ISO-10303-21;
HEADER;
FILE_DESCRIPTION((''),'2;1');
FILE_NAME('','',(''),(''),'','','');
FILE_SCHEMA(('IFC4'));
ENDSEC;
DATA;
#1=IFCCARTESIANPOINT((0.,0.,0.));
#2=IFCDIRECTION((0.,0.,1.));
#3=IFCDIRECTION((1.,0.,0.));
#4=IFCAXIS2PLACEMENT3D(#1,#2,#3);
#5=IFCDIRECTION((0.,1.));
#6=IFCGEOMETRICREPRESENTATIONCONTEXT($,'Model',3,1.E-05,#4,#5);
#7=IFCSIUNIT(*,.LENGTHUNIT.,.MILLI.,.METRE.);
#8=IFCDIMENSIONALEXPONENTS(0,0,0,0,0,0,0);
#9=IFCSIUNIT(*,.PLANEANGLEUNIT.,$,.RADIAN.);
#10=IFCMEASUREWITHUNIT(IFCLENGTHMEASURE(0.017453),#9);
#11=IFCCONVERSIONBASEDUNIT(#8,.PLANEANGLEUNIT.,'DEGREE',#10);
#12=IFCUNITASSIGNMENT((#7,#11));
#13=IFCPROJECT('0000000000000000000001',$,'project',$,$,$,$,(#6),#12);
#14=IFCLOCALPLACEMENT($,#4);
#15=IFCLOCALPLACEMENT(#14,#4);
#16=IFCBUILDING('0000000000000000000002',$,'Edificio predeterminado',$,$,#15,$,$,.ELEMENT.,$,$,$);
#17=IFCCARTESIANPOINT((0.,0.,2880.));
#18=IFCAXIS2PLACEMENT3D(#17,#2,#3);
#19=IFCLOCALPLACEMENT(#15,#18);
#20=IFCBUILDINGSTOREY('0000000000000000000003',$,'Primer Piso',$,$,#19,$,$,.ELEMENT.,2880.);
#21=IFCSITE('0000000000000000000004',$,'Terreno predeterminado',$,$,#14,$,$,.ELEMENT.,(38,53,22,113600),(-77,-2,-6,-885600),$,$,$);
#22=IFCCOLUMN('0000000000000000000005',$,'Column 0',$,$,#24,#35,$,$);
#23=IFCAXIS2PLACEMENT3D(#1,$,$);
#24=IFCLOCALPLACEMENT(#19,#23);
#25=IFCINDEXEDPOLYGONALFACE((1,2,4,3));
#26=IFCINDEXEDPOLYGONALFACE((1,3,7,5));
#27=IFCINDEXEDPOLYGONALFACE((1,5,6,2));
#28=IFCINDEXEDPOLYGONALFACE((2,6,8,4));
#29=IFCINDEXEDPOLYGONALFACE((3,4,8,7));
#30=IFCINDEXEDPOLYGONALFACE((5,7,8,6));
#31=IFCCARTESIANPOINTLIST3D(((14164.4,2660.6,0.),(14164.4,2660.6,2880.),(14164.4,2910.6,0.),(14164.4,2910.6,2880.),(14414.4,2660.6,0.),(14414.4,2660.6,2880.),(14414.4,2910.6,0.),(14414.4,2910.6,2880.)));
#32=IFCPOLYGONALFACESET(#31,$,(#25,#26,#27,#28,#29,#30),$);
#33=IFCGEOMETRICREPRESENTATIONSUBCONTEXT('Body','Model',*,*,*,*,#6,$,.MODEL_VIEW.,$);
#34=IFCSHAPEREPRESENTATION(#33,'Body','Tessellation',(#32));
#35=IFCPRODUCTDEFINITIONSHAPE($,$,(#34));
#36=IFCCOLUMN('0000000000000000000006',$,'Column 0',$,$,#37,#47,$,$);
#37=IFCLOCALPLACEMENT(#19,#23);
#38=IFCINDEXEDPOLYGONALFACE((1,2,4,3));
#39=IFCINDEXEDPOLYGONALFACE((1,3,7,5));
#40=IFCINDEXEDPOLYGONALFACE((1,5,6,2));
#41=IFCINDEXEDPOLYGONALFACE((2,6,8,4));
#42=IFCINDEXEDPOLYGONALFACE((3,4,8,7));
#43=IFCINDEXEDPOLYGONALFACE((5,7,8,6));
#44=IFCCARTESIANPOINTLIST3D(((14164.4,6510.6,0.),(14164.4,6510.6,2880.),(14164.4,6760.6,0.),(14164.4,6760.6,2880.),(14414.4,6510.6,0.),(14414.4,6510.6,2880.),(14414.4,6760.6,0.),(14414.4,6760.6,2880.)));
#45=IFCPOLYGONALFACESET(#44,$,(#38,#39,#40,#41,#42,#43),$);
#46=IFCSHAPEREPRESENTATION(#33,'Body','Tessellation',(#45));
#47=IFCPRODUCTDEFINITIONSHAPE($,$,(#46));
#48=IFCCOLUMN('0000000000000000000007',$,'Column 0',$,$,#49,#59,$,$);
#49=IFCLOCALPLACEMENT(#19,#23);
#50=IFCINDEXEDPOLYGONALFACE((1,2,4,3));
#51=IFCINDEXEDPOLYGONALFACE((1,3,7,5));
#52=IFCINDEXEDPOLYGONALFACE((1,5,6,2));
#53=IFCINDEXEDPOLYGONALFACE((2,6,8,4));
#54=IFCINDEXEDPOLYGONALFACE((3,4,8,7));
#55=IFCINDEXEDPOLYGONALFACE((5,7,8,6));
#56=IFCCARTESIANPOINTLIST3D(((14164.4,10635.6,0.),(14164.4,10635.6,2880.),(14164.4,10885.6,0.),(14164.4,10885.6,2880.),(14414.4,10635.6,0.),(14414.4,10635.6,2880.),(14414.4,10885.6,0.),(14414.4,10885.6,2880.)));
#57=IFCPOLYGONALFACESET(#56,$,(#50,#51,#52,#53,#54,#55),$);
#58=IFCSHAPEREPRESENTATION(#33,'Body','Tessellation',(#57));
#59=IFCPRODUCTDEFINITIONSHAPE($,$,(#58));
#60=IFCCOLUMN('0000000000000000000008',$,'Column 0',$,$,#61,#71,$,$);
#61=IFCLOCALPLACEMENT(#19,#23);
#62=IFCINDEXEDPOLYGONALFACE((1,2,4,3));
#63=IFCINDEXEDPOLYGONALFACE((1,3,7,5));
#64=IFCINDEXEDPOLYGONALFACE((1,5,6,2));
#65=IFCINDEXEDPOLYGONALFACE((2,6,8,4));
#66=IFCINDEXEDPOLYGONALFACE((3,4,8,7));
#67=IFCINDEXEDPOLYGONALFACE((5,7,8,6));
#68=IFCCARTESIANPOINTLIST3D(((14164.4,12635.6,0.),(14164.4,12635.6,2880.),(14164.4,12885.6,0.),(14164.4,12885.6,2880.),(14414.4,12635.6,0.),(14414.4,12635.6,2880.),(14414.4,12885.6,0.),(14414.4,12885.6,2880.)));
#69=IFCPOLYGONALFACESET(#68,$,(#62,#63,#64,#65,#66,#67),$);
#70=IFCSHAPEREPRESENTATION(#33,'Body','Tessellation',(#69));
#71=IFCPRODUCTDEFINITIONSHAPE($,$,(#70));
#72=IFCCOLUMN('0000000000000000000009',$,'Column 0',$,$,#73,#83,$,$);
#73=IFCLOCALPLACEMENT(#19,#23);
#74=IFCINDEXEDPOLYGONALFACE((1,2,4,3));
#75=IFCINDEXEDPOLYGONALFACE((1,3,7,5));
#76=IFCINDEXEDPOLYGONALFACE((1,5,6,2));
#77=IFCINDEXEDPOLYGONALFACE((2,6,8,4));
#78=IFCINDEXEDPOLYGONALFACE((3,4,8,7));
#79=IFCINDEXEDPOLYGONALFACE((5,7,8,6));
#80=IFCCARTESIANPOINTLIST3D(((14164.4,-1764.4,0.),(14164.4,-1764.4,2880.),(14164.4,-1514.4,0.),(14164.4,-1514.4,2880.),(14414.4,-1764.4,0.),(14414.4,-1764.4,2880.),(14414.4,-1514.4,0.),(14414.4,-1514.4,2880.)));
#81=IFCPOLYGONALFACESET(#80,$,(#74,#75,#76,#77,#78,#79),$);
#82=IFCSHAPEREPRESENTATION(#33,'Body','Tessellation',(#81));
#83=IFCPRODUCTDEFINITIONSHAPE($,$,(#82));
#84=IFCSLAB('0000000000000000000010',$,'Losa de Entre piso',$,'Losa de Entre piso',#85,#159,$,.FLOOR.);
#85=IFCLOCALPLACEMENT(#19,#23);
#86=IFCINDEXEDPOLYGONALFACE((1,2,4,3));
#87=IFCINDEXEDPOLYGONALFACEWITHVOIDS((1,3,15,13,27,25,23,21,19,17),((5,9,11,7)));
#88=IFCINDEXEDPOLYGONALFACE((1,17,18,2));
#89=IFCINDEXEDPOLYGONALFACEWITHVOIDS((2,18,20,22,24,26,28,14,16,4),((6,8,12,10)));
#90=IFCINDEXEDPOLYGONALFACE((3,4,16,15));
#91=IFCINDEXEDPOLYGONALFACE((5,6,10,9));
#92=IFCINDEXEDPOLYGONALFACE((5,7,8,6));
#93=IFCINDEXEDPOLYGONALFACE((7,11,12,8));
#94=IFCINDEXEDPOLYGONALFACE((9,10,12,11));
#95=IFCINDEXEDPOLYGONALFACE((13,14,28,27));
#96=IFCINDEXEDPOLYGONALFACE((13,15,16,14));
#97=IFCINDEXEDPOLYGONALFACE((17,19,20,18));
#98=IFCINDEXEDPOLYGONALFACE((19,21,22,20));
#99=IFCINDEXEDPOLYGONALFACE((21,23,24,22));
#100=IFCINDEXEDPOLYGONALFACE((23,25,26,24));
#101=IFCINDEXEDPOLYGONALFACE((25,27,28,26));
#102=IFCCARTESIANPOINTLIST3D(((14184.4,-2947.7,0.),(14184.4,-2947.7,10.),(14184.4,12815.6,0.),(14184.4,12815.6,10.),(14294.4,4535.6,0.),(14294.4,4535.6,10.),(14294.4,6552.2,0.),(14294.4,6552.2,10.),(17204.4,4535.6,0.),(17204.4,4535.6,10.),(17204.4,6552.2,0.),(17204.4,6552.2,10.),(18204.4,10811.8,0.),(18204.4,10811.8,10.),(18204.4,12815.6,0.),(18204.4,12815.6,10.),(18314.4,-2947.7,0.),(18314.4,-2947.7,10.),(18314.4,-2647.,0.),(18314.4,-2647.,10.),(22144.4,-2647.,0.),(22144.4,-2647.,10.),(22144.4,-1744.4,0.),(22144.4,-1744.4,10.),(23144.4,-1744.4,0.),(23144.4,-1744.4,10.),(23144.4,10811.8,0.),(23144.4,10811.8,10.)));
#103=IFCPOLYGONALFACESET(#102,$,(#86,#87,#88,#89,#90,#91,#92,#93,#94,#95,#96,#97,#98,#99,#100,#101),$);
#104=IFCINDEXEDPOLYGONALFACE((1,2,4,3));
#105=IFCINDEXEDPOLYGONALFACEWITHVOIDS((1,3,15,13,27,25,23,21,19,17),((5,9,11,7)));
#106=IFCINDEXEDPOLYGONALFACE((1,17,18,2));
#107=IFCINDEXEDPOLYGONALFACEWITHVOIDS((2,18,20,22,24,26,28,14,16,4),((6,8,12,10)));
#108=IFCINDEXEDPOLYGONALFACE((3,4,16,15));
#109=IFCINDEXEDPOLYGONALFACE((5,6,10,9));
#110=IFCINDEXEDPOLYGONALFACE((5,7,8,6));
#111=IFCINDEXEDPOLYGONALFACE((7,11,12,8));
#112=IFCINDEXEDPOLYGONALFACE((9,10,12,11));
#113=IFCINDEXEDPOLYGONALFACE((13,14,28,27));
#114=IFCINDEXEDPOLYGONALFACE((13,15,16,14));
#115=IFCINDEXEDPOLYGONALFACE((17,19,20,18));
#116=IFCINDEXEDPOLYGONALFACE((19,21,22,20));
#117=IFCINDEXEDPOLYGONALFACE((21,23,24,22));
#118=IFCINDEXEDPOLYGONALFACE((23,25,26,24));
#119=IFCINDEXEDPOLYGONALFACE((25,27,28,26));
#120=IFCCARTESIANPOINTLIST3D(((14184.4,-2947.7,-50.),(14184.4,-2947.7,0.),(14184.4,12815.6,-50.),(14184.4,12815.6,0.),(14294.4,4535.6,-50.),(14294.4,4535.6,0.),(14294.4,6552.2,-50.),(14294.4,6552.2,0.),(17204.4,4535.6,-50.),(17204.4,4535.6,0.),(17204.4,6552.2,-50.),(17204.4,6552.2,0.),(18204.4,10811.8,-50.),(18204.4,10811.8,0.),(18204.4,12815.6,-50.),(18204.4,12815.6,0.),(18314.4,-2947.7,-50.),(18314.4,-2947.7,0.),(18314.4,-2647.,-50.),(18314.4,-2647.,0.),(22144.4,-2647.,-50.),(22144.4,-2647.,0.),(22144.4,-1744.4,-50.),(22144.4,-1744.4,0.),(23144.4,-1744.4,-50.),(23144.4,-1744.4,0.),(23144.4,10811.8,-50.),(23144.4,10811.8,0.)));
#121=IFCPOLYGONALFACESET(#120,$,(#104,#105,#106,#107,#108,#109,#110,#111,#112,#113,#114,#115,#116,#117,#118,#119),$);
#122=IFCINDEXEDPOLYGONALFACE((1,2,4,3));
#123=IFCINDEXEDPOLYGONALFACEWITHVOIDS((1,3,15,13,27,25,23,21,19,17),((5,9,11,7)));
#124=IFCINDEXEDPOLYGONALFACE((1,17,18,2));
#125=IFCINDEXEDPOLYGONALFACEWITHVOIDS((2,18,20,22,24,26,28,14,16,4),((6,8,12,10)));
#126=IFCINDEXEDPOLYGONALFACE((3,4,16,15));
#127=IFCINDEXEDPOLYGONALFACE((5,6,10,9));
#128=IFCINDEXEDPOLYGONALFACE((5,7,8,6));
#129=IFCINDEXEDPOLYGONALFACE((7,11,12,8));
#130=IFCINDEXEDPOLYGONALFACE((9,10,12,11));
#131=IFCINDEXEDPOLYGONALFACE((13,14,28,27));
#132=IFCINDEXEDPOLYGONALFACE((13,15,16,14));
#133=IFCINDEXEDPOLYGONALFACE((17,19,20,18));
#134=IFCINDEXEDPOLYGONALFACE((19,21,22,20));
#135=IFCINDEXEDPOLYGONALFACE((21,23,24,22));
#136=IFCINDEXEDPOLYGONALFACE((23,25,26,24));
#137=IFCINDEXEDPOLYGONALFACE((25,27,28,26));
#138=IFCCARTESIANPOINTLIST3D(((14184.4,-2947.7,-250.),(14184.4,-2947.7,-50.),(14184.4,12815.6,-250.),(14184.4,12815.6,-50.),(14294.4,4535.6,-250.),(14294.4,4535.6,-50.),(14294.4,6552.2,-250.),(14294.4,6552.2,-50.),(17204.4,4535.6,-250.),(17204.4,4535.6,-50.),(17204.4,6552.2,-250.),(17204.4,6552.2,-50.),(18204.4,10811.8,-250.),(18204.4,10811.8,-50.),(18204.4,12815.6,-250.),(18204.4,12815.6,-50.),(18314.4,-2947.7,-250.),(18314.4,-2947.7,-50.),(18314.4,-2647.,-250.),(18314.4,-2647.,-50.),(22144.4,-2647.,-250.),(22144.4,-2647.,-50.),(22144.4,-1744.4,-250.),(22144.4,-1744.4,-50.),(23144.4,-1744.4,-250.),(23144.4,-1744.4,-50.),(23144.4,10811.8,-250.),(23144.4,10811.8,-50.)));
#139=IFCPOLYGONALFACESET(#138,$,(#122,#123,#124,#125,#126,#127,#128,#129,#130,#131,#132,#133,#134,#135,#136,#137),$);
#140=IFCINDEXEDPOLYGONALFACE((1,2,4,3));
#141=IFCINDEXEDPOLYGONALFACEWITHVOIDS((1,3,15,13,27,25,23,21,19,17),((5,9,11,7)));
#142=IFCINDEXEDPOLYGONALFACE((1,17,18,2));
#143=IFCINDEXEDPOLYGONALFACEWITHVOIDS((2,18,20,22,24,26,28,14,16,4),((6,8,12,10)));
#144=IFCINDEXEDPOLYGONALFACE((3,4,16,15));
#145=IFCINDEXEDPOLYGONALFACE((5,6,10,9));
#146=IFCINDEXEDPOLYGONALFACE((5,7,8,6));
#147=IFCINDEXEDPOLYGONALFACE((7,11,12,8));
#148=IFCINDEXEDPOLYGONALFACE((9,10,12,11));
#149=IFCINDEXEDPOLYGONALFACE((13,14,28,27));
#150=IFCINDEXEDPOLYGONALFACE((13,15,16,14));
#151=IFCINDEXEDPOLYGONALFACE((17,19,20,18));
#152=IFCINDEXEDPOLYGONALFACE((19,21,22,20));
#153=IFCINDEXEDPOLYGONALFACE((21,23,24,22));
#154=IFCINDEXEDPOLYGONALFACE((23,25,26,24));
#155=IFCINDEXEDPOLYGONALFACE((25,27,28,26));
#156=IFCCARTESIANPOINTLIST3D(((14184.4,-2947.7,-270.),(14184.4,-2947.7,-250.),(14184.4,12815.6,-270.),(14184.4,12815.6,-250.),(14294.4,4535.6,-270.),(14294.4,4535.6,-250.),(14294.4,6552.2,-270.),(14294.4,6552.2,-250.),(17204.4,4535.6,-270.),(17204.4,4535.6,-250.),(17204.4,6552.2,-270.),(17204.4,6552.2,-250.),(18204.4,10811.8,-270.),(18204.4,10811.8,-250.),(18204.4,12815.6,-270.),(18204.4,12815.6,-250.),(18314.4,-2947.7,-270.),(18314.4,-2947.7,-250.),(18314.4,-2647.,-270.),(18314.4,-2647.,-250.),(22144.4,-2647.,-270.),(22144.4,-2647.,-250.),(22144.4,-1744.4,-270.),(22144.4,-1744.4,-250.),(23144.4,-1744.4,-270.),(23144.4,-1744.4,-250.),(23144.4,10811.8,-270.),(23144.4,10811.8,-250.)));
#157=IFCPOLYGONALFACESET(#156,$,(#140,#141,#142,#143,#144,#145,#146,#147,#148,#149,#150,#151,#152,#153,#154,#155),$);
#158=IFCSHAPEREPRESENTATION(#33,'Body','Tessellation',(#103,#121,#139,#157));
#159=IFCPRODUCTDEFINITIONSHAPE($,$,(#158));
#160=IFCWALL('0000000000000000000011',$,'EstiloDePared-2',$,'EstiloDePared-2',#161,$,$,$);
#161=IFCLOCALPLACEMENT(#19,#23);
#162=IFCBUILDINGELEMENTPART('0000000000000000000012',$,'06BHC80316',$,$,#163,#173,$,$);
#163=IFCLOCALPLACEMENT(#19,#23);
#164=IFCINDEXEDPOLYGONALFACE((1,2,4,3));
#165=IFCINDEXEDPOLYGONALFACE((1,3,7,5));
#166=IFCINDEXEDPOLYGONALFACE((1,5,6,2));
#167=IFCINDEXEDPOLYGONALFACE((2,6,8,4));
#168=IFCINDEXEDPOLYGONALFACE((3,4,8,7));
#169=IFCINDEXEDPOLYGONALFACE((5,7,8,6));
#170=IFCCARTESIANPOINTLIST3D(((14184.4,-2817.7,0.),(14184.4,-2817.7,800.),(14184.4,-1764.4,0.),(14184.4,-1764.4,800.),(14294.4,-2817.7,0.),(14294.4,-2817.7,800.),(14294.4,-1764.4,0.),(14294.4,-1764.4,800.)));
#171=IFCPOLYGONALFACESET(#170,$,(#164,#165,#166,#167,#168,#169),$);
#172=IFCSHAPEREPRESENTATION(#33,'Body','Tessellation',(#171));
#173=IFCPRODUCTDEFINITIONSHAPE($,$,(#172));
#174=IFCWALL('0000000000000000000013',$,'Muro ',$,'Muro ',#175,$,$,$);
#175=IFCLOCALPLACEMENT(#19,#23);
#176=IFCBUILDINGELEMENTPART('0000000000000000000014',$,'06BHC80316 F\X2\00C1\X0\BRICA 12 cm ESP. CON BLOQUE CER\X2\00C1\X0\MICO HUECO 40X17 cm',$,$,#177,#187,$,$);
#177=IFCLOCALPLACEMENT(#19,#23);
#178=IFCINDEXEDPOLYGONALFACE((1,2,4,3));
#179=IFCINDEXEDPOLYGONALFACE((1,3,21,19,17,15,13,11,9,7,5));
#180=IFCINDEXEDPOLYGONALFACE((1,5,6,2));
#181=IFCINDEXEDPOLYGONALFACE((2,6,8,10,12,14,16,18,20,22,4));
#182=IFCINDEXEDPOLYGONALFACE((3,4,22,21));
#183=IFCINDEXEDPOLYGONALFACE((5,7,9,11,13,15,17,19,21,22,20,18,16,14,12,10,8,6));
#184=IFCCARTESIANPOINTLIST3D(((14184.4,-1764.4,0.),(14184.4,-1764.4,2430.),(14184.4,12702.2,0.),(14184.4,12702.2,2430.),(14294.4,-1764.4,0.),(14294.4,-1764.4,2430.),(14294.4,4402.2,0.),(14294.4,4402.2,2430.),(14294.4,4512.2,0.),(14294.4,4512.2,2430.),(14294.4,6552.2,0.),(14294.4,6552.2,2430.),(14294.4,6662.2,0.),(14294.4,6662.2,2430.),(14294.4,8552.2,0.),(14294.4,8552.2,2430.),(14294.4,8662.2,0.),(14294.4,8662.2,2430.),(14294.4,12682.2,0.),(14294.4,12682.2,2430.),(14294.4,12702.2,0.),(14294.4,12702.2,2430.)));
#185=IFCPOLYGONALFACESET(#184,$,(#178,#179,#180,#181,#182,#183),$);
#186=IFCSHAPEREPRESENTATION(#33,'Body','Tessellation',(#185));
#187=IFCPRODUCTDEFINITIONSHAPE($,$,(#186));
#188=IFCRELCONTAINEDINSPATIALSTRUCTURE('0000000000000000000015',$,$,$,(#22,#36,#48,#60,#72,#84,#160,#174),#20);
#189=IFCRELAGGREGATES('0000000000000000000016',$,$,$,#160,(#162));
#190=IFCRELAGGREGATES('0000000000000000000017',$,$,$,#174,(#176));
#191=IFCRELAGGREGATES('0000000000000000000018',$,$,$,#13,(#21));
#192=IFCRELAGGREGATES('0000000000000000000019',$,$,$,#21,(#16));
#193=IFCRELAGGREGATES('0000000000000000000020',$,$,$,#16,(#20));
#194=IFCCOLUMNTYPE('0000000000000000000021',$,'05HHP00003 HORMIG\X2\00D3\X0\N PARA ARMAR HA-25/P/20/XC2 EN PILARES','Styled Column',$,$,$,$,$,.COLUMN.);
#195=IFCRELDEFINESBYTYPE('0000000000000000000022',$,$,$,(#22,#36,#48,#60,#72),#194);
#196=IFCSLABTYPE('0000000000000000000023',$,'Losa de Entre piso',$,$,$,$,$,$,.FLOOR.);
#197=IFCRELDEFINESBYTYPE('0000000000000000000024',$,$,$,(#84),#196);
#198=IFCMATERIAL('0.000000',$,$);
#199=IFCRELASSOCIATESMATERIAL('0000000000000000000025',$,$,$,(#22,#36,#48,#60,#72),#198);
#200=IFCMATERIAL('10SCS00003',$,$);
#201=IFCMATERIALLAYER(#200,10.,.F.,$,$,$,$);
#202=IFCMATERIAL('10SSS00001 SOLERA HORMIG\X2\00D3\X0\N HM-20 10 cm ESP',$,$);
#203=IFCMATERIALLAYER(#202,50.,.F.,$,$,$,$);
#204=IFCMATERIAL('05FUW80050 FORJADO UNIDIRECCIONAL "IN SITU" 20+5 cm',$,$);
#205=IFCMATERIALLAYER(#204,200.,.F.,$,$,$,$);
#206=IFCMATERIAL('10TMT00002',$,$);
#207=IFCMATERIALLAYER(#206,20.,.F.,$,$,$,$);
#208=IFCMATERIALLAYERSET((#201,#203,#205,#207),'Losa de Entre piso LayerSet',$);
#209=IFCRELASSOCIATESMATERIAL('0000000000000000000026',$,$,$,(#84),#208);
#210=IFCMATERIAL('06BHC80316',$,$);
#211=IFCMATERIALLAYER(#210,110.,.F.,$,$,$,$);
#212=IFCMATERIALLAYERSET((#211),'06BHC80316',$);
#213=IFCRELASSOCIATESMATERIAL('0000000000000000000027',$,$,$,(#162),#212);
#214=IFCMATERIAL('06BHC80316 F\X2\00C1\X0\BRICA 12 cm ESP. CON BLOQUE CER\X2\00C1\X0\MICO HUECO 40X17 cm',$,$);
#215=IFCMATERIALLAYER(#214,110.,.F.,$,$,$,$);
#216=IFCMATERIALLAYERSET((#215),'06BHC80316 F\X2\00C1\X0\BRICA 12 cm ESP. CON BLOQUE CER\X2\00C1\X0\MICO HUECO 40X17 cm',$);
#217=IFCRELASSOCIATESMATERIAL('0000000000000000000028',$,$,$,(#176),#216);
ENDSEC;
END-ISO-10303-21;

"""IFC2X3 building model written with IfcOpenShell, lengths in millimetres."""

from ifc_helpers import new_model, entity, si_unit, converted_unit, direction, frame, origin_with_axes, place, context, subcontext, project, spatial, polyline, outline, extrude, material, layer, layer_set, layer_usage, type_object, element, aggregate, save


model = new_model("IFC2X3")

# Units and contexts
model_context = context("Model", 3, precision=1e-05, world=origin_with_axes(), true_north=direction((0.0, 1.0)))
body_context = subcontext(model_context, "Body", "Model", "MODEL_VIEW")
ifc_project = project(units=[si_unit("LENGTHUNIT", "METRE", prefix="MILLI"), converted_unit("PLANEANGLEUNIT", "DEGREE", entity("IfcLengthMeasure", 0.017453), si_unit("PLANEANGLEUNIT", "RADIAN"), dimensions=[0, 0, 0, 0, 0, 0, 0])], contexts=[model_context])

# Site, building, storey
site_placement = place(None, origin_with_axes())
site = spatial("IfcSite", under=ifc_project, at=site_placement, Name="Terreno predeterminado", CompositionType="ELEMENT", RefLatitude=(38, 53, 22, 113600), RefLongitude=(-77, -2, -6, -885600))
building_placement = place(site_placement, origin_with_axes())
building = spatial("IfcBuilding", under=site, at=building_placement, Name="Edificio predeterminado", CompositionType="ELEMENT")
storey_placement = place(building_placement, frame((0.0, 0.0, 2880.0), z_axis=(0.0, 0.0, 1.0), x_axis=(1.0, 0.0, 0.0)))
storey = spatial("IfcBuildingStorey", under=building, at=storey_placement, Name="Primer Piso", CompositionType="ELEMENT", Elevation=2880.0)

# Columns
ifc_material_1 = material(Name="0.000000")
column_type = type_object("IfcColumnType", Name="05HHP00003 HORMIGÓN PARA ARMAR HA-25/P/20/XC2 EN PILARES", Description="Styled Column", PredefinedType="COLUMN")
for number, where, z_axis, x_axis, name in (
    (1, (14289.4, 2785.6, 0.0), (0.0, 0.0, 1.0), (1.0, 0.0, 0.0), "Column 0"),
    (2, (14289.4, 6635.6, 0.0), (0.0, 0.0, 1.0), (1.0, 0.0, 0.0), "Column 0"),
    (3, (14289.4, 10760.6, 0.0), (0.0, 0.0, 1.0), (1.0, 0.0, 0.0), "Column 0"),
    (4, (14289.4, 12760.6, 0.0), (0.0, 0.0, 1.0), (1.0, 0.0, 0.0), "Column 0"),
    (5, (14289.4, -1639.4, 0.0), (0.0, 0.0, 1.0), (1.0, 0.0, 0.0), "Column 0"),
):
    element("IfcColumn", number, at=place(storey_placement, frame(where, z_axis=z_axis, x_axis=x_axis)), inside=storey, type_object=column_type, material=ifc_material_1, Name=name, context=body_context, shape_type="SweptSolid", body=[
        extrude(outline(polyline([(-125.0, -125.0), (125.0, -125.0), (125.0, 125.0), (-125.0, 125.0), (-125.0, -125.0)])), origin_with_axes(), (0.0, 0.0, 1.0), 2880.0),
    ])

# Slab
ifc_material_2 = material(Name="10SCS00003")
ifc_layer_1 = layer(ifc_material_2, 10.0, ventilated=False)
ifc_material_3 = material(Name="10SSS00001 SOLERA HORMIGÓN HM-20 10 cm ESP")
ifc_layer_2 = layer(ifc_material_3, 50.0, ventilated=False)
ifc_material_4 = material(Name="05FUW80050 FORJADO UNIDIRECCIONAL \"IN SITU\" 20+5 cm")
ifc_layer_3 = layer(ifc_material_4, 200.0, ventilated=False)
ifc_material_5 = material(Name="10TMT00002")
ifc_layer_4 = layer(ifc_material_5, 20.0, ventilated=False)
ifc_layer_set_1 = layer_set([ifc_layer_1, ifc_layer_2, ifc_layer_3, ifc_layer_4], Name="Losa de Entre piso LayerSet")
ifc_layer_usage_1 = layer_usage(ifc_layer_set_1, "AXIS3", "NEGATIVE", 0.0)
slab_type = type_object("IfcSlabType", Name="Losa de Entre piso", PredefinedType="FLOOR")
slab_placement = place(storey_placement, frame((0.0, 0.0, -2880.0), z_axis=(0.0, 0.0, 1.0), x_axis=(1.0, 0.0, 0.0)))
element("IfcSlab", 6, at=slab_placement, inside=storey, type_object=slab_type, material=ifc_layer_usage_1, Name="Losa de Entre piso", ObjectType="Losa de Entre piso", PredefinedType="FLOOR", context=body_context, shape_type="SweptSolid", body=[
    extrude(outline(polyline([(0.0, 15763.4), (4130.0, 15763.4), (4130.0, 15462.6), (7960.0, 15462.6), (7960.0, 14560.0), (8960.0, 14560.0), (8960.0, 2003.8), (4020.0, 2003.8), (4020.0, 0.0), (0.0, 0.0), (0.0, 15763.4)]), holes=[polyline([(110.0, 6263.4), (3020.0, 6263.4), (3020.0, 8280.0), (110.0, 8280.0), (110.0, 6263.4)])]), frame((14184.4, 12815.6, 2880.0), z_axis=(0.0, 0.0, -1.0), x_axis=(1.0, 0.0, 0.0)), (0.0, 0.0, -1.0), 10.0),
    extrude(outline(polyline([(0.0, 15763.4), (4130.0, 15763.4), (4130.0, 15462.6), (7960.0, 15462.6), (7960.0, 14560.0), (8960.0, 14560.0), (8960.0, 2003.8), (4020.0, 2003.8), (4020.0, 0.0), (0.0, 0.0), (0.0, 15763.4)]), holes=[polyline([(110.0, 6263.4), (3020.0, 6263.4), (3020.0, 8280.0), (110.0, 8280.0), (110.0, 6263.4)])]), frame((14184.4, 12815.6, 2830.0), z_axis=(0.0, 0.0, -1.0), x_axis=(1.0, 0.0, 0.0)), (0.0, 0.0, -1.0), 50.0),
    extrude(outline(polyline([(0.0, 15763.4), (4130.0, 15763.4), (4130.0, 15462.6), (7960.0, 15462.6), (7960.0, 14560.0), (8960.0, 14560.0), (8960.0, 2003.8), (4020.0, 2003.8), (4020.0, 0.0), (0.0, 0.0), (0.0, 15763.4)]), holes=[polyline([(110.0, 6263.4), (3020.0, 6263.4), (3020.0, 8280.0), (110.0, 8280.0), (110.0, 6263.4)])]), frame((14184.4, 12815.6, 2630.0), z_axis=(0.0, 0.0, -1.0), x_axis=(1.0, 0.0, 0.0)), (0.0, 0.0, -1.0), 200.0),
    extrude(outline(polyline([(0.0, 15763.4), (4130.0, 15763.4), (4130.0, 15462.6), (7960.0, 15462.6), (7960.0, 14560.0), (8960.0, 14560.0), (8960.0, 2003.8), (4020.0, 2003.8), (4020.0, 0.0), (0.0, 0.0), (0.0, 15763.4)]), holes=[polyline([(110.0, 6263.4), (3020.0, 6263.4), (3020.0, 8280.0), (110.0, 8280.0), (110.0, 6263.4)])]), frame((14184.4, 12815.6, 2610.0), z_axis=(0.0, 0.0, -1.0), x_axis=(1.0, 0.0, 0.0)), (0.0, 0.0, -1.0), 20.0),
])

# Walls, building element parts
wall_1_placement = place(storey_placement, frame((14239.4, -2817.7, 0.0), z_axis=(0.0, 0.0, 1.0), x_axis=(0.0, 1.0, 0.0)))
wall_1 = element("IfcWall", 7, at=wall_1_placement, inside=storey, Name="EstiloDePared-2", ObjectType="EstiloDePared-2")
ifc_material_6 = material(Name="06BHC80316")
ifc_layer_5 = layer(ifc_material_6, 110.0, ventilated=False)
ifc_layer_set_2 = layer_set([ifc_layer_5], Name="06BHC80316")
ifc_layer_usage_2 = layer_usage(ifc_layer_set_2, "AXIS2", "NEGATIVE", -55.0)
building_element_part_1_placement = place(wall_1_placement, origin_with_axes())
building_element_part_1 = element("IfcBuildingElementPart", 8, at=building_element_part_1_placement, material=ifc_layer_usage_2, Name="06BHC80316", context=body_context, shape_type="SweptSolid", body=[
    extrude(outline(polyline([(1053.4, 55.0), (1053.4, -55.0), (0.0, -55.0), (0.0, 55.0), (1053.4, 55.0)])), origin_with_axes(), (0.0, 0.0, 1.0), 800.0),
])
aggregate(wall_1, [building_element_part_1])
wall_2_placement = place(storey_placement, frame((14239.4, -1764.4, 0.0), z_axis=(0.0, 0.0, 1.0), x_axis=(0.0, 1.0, 0.0)))
wall_2 = element("IfcWall", 9, at=wall_2_placement, inside=storey, Name="Muro ", ObjectType="Muro ")
ifc_material_7 = material(Name="06BHC80316 FÁBRICA 12 cm ESP. CON BLOQUE CERÁMICO HUECO 40X17 cm")
ifc_layer_6 = layer(ifc_material_7, 110.0, ventilated=False)
ifc_layer_set_3 = layer_set([ifc_layer_6], Name="06BHC80316 FÁBRICA 12 cm ESP. CON BLOQUE CERÁMICO HUECO 40X17 cm")
ifc_layer_usage_3 = layer_usage(ifc_layer_set_3, "AXIS2", "NEGATIVE", -55.0)
building_element_part_2_placement = place(wall_2_placement, origin_with_axes())
building_element_part_2 = element("IfcBuildingElementPart", 10, at=building_element_part_2_placement, material=ifc_layer_usage_3, Name="06BHC80316 FÁBRICA 12 cm ESP. CON BLOQUE CERÁMICO HUECO 40X17 cm", context=body_context, shape_type="SweptSolid", body=[
    extrude(outline(polyline([(14466.6, 55.0), (14466.6, -55.0), (14446.6, -55.0), (10426.6, -55.0), (10316.6, -55.0), (8426.6, -55.0), (8316.6, -55.0), (6276.6, -55.0), (6166.6, -55.0), (0.0, -55.0), (0.0, 55.0), (14466.6, 55.0)])), origin_with_axes(), (0.0, 0.0, 1.0), 2430.0),
])
aggregate(wall_2, [building_element_part_2])

save(model, "model.ifc")
